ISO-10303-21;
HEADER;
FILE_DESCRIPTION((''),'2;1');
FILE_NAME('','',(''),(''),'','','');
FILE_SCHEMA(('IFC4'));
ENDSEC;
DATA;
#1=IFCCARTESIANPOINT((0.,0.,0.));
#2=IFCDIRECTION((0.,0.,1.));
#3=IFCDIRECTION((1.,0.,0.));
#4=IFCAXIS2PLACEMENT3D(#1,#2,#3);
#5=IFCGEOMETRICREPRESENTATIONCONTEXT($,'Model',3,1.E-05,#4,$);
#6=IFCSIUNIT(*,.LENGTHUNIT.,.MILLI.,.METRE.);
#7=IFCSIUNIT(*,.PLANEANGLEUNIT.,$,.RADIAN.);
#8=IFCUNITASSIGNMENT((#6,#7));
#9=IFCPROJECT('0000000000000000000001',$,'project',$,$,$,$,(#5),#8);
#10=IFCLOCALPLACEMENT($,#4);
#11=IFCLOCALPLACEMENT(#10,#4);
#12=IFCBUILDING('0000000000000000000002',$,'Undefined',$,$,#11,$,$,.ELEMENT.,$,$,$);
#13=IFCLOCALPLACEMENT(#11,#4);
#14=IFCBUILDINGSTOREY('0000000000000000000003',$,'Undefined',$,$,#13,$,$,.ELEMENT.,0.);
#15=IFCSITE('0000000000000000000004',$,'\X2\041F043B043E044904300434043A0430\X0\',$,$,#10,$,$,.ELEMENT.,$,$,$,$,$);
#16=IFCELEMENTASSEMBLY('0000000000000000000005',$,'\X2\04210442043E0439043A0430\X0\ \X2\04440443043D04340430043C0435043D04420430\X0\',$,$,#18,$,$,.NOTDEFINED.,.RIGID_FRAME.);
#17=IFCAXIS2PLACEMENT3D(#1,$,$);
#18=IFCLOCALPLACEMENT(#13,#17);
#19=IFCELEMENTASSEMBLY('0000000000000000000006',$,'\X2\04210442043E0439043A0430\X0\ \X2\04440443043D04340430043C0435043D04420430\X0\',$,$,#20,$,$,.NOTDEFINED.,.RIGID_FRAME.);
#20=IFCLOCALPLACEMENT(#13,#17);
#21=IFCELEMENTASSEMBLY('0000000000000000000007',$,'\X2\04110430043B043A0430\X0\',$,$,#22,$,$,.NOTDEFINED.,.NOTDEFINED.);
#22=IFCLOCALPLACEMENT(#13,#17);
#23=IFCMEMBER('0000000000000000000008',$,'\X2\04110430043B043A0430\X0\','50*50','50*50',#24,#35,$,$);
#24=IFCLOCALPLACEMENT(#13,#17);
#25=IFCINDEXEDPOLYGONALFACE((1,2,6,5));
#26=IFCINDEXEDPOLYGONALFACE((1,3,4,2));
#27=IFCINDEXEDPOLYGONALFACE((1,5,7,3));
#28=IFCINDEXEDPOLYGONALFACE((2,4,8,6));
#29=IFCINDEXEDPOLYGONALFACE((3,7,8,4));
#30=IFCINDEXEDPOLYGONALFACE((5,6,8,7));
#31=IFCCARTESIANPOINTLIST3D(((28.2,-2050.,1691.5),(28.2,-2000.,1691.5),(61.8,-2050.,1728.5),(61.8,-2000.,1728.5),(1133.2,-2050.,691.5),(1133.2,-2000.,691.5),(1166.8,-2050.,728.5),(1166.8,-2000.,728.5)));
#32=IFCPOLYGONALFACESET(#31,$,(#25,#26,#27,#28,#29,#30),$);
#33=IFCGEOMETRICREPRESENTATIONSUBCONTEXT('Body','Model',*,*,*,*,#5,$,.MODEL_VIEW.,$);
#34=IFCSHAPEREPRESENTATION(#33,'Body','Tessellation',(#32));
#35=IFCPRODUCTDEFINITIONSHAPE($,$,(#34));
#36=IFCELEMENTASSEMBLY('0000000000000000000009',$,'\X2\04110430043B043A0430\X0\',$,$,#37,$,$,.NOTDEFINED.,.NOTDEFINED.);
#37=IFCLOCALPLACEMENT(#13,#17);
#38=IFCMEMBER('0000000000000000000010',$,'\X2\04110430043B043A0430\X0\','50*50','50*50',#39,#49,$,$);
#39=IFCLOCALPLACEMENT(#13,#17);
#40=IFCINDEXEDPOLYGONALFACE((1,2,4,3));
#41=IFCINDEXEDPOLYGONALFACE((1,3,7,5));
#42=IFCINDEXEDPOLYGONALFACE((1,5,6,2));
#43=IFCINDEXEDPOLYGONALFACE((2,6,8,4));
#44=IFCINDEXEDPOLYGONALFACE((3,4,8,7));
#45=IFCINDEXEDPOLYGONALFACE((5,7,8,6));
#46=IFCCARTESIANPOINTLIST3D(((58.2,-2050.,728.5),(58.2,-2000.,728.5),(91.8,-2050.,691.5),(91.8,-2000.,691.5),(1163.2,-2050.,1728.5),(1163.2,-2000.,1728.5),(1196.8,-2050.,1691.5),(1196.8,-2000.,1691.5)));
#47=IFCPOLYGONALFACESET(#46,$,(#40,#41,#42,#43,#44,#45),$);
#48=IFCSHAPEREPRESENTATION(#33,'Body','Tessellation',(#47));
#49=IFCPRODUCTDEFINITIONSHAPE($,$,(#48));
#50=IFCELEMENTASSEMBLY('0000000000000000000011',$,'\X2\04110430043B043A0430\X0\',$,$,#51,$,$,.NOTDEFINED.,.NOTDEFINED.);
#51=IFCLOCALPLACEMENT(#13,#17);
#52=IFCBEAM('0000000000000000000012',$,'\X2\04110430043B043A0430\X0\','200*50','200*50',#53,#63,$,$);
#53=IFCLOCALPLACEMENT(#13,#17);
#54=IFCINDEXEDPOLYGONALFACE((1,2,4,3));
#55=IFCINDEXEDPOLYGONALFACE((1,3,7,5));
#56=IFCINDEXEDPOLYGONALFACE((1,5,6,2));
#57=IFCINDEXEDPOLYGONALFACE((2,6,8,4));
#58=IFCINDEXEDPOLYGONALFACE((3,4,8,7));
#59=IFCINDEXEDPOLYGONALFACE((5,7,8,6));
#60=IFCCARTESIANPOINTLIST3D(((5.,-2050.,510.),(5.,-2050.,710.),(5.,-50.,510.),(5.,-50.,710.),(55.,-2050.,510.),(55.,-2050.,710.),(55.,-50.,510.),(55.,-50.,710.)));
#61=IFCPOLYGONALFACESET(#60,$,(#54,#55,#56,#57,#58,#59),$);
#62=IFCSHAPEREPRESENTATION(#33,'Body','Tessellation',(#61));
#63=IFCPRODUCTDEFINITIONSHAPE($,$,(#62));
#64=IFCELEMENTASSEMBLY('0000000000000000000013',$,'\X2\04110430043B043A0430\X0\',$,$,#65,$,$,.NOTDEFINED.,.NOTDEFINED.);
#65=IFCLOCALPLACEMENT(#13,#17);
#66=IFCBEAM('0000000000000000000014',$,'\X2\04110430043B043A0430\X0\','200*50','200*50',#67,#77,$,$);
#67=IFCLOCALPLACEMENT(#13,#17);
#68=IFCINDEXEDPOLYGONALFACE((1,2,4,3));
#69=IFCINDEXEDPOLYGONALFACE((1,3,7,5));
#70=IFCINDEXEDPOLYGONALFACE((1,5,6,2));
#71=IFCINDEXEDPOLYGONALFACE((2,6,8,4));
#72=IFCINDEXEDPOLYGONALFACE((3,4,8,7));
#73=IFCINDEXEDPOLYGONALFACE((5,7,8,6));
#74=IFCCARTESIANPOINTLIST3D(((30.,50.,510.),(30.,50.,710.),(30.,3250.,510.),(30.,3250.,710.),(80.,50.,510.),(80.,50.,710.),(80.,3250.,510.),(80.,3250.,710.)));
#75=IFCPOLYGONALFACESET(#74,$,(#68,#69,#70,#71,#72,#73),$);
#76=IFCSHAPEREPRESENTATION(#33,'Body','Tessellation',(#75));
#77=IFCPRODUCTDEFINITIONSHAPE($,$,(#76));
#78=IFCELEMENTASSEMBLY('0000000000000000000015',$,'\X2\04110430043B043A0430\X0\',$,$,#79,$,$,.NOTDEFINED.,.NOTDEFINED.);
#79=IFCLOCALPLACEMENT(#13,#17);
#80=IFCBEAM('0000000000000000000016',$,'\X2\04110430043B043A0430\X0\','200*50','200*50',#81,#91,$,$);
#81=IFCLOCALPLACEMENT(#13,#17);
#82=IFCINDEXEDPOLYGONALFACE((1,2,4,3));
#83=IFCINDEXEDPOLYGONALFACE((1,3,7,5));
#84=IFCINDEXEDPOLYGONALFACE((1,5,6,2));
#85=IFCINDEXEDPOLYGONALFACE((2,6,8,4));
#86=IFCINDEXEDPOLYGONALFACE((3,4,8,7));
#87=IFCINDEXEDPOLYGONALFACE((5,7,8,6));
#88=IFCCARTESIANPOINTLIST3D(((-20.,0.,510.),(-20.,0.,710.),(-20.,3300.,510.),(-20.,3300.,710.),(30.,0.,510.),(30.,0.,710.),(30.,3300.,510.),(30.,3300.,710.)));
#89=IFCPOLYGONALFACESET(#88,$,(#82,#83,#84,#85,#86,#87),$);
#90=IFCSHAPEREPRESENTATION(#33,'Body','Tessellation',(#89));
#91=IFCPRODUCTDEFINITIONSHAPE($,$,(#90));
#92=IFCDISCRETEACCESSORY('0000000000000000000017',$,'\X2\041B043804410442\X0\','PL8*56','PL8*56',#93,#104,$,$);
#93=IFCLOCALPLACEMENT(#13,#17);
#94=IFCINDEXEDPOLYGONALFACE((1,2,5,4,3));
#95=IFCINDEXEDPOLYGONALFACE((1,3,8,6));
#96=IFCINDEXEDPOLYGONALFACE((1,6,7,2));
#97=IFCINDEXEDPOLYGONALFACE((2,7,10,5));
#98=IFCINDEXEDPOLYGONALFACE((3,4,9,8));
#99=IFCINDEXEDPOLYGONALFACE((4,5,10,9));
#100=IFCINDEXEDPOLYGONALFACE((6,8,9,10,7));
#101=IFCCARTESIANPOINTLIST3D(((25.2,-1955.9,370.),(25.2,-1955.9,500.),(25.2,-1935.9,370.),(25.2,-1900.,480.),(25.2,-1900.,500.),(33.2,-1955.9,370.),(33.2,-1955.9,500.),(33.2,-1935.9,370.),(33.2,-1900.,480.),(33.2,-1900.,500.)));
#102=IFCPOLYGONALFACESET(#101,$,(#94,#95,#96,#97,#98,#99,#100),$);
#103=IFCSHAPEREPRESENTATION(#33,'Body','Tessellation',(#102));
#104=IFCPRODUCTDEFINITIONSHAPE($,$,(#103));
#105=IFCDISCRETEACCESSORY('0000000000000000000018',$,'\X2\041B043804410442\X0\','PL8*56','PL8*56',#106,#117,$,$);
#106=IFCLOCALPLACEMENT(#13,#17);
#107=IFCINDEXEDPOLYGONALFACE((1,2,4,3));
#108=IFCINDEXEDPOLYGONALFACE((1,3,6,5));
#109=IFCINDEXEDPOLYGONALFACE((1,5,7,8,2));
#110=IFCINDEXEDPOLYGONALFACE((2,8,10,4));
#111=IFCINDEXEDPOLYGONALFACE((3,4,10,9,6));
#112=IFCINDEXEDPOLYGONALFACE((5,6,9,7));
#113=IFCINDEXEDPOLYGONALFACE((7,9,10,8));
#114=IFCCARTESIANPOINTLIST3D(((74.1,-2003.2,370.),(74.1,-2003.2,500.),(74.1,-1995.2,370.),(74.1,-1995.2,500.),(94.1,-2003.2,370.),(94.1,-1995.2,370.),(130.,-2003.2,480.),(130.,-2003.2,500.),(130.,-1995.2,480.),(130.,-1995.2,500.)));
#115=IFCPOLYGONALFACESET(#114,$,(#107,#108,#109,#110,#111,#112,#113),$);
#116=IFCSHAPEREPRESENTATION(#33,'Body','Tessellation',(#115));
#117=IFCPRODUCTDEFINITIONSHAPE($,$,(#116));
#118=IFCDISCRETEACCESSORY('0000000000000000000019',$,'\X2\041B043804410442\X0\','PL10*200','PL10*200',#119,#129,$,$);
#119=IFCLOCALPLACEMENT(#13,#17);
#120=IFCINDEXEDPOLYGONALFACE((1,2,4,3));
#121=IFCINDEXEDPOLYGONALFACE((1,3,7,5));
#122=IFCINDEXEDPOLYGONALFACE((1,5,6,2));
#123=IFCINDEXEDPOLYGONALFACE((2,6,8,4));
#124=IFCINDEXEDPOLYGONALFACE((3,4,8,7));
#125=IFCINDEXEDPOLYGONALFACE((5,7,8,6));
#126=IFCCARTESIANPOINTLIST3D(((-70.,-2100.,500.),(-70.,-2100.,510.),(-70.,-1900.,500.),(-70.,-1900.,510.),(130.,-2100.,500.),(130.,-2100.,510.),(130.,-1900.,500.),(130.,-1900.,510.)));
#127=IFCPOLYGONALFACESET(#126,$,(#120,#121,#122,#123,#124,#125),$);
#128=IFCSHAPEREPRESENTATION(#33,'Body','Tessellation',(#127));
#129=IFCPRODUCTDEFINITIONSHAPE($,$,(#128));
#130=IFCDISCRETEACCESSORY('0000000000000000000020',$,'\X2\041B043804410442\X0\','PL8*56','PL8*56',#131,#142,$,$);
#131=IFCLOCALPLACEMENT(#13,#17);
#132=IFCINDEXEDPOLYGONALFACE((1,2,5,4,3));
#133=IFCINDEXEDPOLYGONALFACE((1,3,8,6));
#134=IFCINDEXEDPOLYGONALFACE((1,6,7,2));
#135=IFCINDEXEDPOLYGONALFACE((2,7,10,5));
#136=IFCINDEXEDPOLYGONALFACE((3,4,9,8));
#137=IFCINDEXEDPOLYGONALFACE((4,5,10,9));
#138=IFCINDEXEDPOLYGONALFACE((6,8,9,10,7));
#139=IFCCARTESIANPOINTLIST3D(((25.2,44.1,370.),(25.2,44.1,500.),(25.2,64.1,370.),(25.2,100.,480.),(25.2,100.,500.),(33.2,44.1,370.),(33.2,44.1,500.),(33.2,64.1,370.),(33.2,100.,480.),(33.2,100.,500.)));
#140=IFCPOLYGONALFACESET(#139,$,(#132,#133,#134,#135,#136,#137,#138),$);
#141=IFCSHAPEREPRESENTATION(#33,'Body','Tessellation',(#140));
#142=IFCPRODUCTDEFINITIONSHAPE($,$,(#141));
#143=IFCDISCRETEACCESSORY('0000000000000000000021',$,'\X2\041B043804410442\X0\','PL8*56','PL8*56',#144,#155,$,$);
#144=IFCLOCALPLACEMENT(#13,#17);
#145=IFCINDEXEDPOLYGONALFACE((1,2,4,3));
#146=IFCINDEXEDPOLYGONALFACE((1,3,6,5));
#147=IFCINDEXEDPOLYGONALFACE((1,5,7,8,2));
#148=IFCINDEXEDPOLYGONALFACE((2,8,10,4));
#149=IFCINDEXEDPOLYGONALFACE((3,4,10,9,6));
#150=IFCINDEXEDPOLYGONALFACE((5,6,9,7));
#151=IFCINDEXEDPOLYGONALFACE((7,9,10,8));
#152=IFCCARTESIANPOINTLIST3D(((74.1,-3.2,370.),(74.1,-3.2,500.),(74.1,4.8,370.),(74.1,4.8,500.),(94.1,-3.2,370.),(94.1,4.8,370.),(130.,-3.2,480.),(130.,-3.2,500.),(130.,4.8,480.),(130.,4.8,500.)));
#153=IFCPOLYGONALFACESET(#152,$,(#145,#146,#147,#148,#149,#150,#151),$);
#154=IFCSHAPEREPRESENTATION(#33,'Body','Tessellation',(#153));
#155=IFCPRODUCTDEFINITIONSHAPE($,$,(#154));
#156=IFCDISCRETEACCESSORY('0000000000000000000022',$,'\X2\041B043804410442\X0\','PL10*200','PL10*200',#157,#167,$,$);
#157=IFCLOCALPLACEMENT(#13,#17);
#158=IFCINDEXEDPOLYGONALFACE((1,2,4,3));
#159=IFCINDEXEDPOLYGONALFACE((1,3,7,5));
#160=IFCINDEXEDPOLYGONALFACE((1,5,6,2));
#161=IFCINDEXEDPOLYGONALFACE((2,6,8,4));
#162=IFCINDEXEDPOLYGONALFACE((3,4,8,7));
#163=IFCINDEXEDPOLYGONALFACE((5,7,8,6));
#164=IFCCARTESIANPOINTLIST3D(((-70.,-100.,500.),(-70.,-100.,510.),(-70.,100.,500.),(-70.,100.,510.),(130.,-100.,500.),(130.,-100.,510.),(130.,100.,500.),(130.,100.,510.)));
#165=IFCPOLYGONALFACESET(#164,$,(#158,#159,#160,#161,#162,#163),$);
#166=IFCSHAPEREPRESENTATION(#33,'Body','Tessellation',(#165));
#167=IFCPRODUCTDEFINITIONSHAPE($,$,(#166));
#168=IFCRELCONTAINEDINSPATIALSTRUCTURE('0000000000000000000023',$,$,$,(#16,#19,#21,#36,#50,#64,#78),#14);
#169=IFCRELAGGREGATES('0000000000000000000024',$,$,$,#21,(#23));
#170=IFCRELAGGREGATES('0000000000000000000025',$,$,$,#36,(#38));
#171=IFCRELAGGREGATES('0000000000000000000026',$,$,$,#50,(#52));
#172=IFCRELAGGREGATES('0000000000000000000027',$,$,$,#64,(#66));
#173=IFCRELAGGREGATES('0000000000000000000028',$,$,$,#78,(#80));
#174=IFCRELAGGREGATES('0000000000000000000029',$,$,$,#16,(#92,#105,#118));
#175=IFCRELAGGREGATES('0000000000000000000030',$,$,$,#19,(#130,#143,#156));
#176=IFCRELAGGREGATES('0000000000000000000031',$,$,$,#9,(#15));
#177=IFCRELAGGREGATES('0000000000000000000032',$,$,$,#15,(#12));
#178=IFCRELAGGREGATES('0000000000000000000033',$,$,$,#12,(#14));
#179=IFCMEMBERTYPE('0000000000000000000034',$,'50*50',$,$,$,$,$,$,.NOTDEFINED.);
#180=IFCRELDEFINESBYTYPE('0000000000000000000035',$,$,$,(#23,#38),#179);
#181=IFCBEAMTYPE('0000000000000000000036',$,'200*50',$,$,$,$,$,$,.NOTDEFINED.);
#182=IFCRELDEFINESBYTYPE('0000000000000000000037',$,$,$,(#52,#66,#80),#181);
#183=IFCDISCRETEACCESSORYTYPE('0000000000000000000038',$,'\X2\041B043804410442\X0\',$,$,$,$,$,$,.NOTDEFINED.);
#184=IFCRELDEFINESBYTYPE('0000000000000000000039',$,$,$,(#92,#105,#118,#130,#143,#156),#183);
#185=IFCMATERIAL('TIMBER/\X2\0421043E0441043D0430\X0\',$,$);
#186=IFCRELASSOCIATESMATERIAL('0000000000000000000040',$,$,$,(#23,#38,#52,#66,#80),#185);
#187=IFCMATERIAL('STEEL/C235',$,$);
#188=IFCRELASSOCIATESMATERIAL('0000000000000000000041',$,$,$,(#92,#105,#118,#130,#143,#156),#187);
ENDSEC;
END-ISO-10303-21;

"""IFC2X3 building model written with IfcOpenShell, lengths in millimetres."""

from ifc_helpers import new_model, si_unit, frame, origin_with_axes, origin_2d_with_axis, place, context, subcontext, project, spatial, polyline, rectangle, outline, extrude, material, type_object, element, aggregate, save


model = new_model("IFC2X3")

# Units and contexts
model_context = context("Model", 3, precision=1e-05, world=origin_with_axes())
body_context = subcontext(model_context, "Body", "Model", "MODEL_VIEW")
ifc_project = project(units=[si_unit("LENGTHUNIT", "METRE", prefix="MILLI"), si_unit("PLANEANGLEUNIT", "RADIAN")], contexts=[model_context])

# Site, building, storey
site_placement = place(None, origin_with_axes())
site = spatial("IfcSite", under=ifc_project, at=site_placement, Name="Площадка", CompositionType="ELEMENT")
building_placement = place(site_placement, origin_with_axes())
building = spatial("IfcBuilding", under=site, at=building_placement, Name="Undefined", CompositionType="ELEMENT")
storey_placement = place(building_placement, origin_with_axes())
storey = spatial("IfcBuildingStorey", under=building, at=storey_placement, Name="Undefined", CompositionType="ELEMENT", Elevation=0.0)

# Element assemblies
ifc_material_1 = material(Name="TIMBER/Сосна")
assembly_1_placement = place(storey_placement, origin_with_axes())
assembly_1 = element("IfcElementAssembly", 1, at=assembly_1_placement, inside=storey, Name="Стойка фундамента", AssemblyPlace="NOTDEFINED", PredefinedType="RIGID_FRAME")
ifc_material_2 = material(Name="STEEL/C235")
assembly_2_placement = place(storey_placement, origin_with_axes())
assembly_2 = element("IfcElementAssembly", 2, at=assembly_2_placement, inside=storey, Name="Стойка фундамента", AssemblyPlace="NOTDEFINED", PredefinedType="RIGID_FRAME")

# Element assemblies, members
assembly_3_placement = place(storey_placement, origin_with_axes())
assembly_3 = element("IfcElementAssembly", 3, at=assembly_3_placement, inside=storey, Name="Балка", AssemblyPlace="NOTDEFINED", PredefinedType="NOTDEFINED")
member_type = type_object("IfcMemberType", Name="50*50", PredefinedType="NOTDEFINED")
member_1_placement = place(assembly_3_placement, frame((1150.0, -2025.0, 710.0), z_axis=(0.0, 1.0, 0.0), x_axis=(-0.741456, 0.0, 0.671001)))
member_1 = element("IfcMember", 4, at=member_1_placement, type_object=member_type, material=ifc_material_1, Name="Балка", Description="50*50", ObjectType="50*50", context=body_context, shape_type="SweptSolid", body=[
    extrude(rectangle(XDim=50.0, YDim=50.0, at=origin_2d_with_axis()), frame((1490.3, 0.0, 0.0), z_axis=(-1.0, 0.0, 0.0), x_axis=(0.0, -1.0, 0.0)), (0.0, 0.0, 1.0), 1490.3),
])
aggregate(assembly_3, [member_1])
assembly_4_placement = place(storey_placement, origin_with_axes())
assembly_4 = element("IfcElementAssembly", 5, at=assembly_4_placement, inside=storey, Name="Балка", AssemblyPlace="NOTDEFINED", PredefinedType="NOTDEFINED")
member_2_placement = place(assembly_4_placement, frame((75.0, -2025.0, 710.0), z_axis=(0.0, 1.0, 0.0), x_axis=(0.741456, 0.0, 0.671001)))
member_2 = element("IfcMember", 6, at=member_2_placement, type_object=member_type, material=ifc_material_1, Name="Балка", Description="50*50", ObjectType="50*50", context=body_context, shape_type="SweptSolid", body=[
    extrude(rectangle(XDim=50.0, YDim=50.0, at=origin_2d_with_axis()), frame((1490.3, 0.0, 0.0), z_axis=(-1.0, 0.0, 0.0), x_axis=(0.0, -1.0, 0.0)), (0.0, 0.0, 1.0), 1490.3),
])
aggregate(assembly_4, [member_2])

# Element assemblies, beams
assembly_5_placement = place(storey_placement, origin_with_axes())
assembly_5 = element("IfcElementAssembly", 7, at=assembly_5_placement, inside=storey, Name="Балка", AssemblyPlace="NOTDEFINED", PredefinedType="NOTDEFINED")
beam_type = type_object("IfcBeamType", Name="200*50", PredefinedType="NOTDEFINED")
beam_1_placement = place(assembly_5_placement, frame((30.0, -2050.0, 610.0), z_axis=(0.0, 0.0, -1.0), x_axis=(0.0, 1.0, 0.0)))
beam_1 = element("IfcBeam", 8, at=beam_1_placement, type_object=beam_type, material=ifc_material_1, Name="Балка", Description="200*50", ObjectType="200*50", context=body_context, shape_type="SweptSolid", body=[
    extrude(rectangle(XDim=50.0, YDim=200.0, at=origin_2d_with_axis()), frame((2000.0, 0.0, 0.0), z_axis=(-1.0, 0.0, 0.0), x_axis=(0.0, -1.0, 0.0)), (0.0, 0.0, 1.0), 2000.0),
])
aggregate(assembly_5, [beam_1])
assembly_6_placement = place(storey_placement, origin_with_axes())
assembly_6 = element("IfcElementAssembly", 9, at=assembly_6_placement, inside=storey, Name="Балка", AssemblyPlace="NOTDEFINED", PredefinedType="NOTDEFINED")
beam_2_placement = place(assembly_6_placement, frame((55.0, 50.0, 610.0), z_axis=(0.0, 0.0, -1.0), x_axis=(0.0, 1.0, 0.0)))
beam_2 = element("IfcBeam", 10, at=beam_2_placement, type_object=beam_type, material=ifc_material_1, Name="Балка", Description="200*50", ObjectType="200*50", context=body_context, shape_type="SweptSolid", body=[
    extrude(rectangle(XDim=50.0, YDim=200.0, at=origin_2d_with_axis()), frame((3200.0, 0.0, 0.0), z_axis=(-1.0, 0.0, 0.0), x_axis=(0.0, -1.0, 0.0)), (0.0, 0.0, 1.0), 3200.0),
])
aggregate(assembly_6, [beam_2])
assembly_7_placement = place(storey_placement, origin_with_axes())
assembly_7 = element("IfcElementAssembly", 11, at=assembly_7_placement, inside=storey, Name="Балка", AssemblyPlace="NOTDEFINED", PredefinedType="NOTDEFINED")
beam_3_placement = place(assembly_7_placement, frame((5.0, 0.0, 610.0), z_axis=(0.0, 0.0, -1.0), x_axis=(0.0, 1.0, 0.0)))
beam_3 = element("IfcBeam", 12, at=beam_3_placement, type_object=beam_type, material=ifc_material_1, Name="Балка", Description="200*50", ObjectType="200*50", context=body_context, shape_type="SweptSolid", body=[
    extrude(rectangle(XDim=50.0, YDim=200.0, at=origin_2d_with_axis()), frame((3300.0, 0.0, 0.0), z_axis=(-1.0, 0.0, 0.0), x_axis=(0.0, -1.0, 0.0)), (0.0, 0.0, 1.0), 3300.0),
])
aggregate(assembly_7, [beam_3])

# Discrete accessories
discrete_accessory_type = type_object("IfcDiscreteAccessoryType", Name="Лист")
discrete_accessory_1_placement = place(assembly_1_placement, frame((29.2, -1955.9, 500.0), z_axis=(-1.0, 0.0, 0.0), x_axis=(0.0, 1.0, 0.0)))
discrete_accessory_1 = element("IfcDiscreteAccessory", 13, at=discrete_accessory_1_placement, type_object=discrete_accessory_type, material=ifc_material_2, Name="Лист", Description="PL8*56", ObjectType="PL8*56", context=body_context, shape_type="SweptSolid", body=[
    extrude(outline(polyline([(0.0, 0.0), (55.9, 0.0), (55.9, 20.0), (20.0, 130.0), (0.0, 130.0), (0.0, 0.0)])), frame((0.0, 0.0, -4.0), z_axis=(0.0, 0.0, 1.0), x_axis=(1.0, 0.0, 0.0)), (0.0, 0.0, 1.0), 8.0),
])
discrete_accessory_2_placement = place(assembly_1_placement, frame((74.1, -1999.2, 500.0), z_axis=(0.0, 1.0, 0.0), x_axis=(1.0, 0.0, 0.0)))
discrete_accessory_2 = element("IfcDiscreteAccessory", 14, at=discrete_accessory_2_placement, type_object=discrete_accessory_type, material=ifc_material_2, Name="Лист", Description="PL8*56", ObjectType="PL8*56", context=body_context, shape_type="SweptSolid", body=[
    extrude(outline(polyline([(0.0, 0.0), (55.9, 0.0), (55.9, 20.0), (20.0, 130.0), (0.0, 130.0), (0.0, 0.0)])), frame((0.0, 0.0, -4.0), z_axis=(0.0, 0.0, 1.0), x_axis=(1.0, 0.0, 0.0)), (0.0, 0.0, 1.0), 8.0),
])
discrete_accessory_3_placement = place(assembly_1_placement, frame((-70.0, -1900.0, 505.0), z_axis=(0.0, 0.0, 1.0), x_axis=(0.0, -1.0, 0.0)))
discrete_accessory_3 = element("IfcDiscreteAccessory", 15, at=discrete_accessory_3_placement, type_object=discrete_accessory_type, material=ifc_material_2, Name="Лист", Description="PL10*200", ObjectType="PL10*200", context=body_context, shape_type="SweptSolid", body=[
    extrude(outline(polyline([(0.0, 0.0), (200.0, 0.0), (200.0, 200.0), (0.0, 200.0), (0.0, 0.0)])), frame((0.0, 0.0, -5.0), z_axis=(0.0, 0.0, 1.0), x_axis=(1.0, 0.0, 0.0)), (0.0, 0.0, 1.0), 10.0),
])
aggregate(assembly_1, [discrete_accessory_1, discrete_accessory_2, discrete_accessory_3])
discrete_accessory_4_placement = place(assembly_2_placement, frame((29.2, 44.1, 500.0), z_axis=(-1.0, 0.0, 0.0), x_axis=(0.0, 1.0, 0.0)))
discrete_accessory_4 = element("IfcDiscreteAccessory", 16, at=discrete_accessory_4_placement, type_object=discrete_accessory_type, material=ifc_material_2, Name="Лист", Description="PL8*56", ObjectType="PL8*56", context=body_context, shape_type="SweptSolid", body=[
    extrude(outline(polyline([(0.0, 0.0), (55.9, 0.0), (55.9, 20.0), (20.0, 130.0), (0.0, 130.0), (0.0, 0.0)])), frame((0.0, 0.0, -4.0), z_axis=(0.0, 0.0, 1.0), x_axis=(1.0, 0.0, 0.0)), (0.0, 0.0, 1.0), 8.0),
])
discrete_accessory_5_placement = place(assembly_2_placement, frame((74.1, 0.8, 500.0), z_axis=(0.0, 1.0, 0.0), x_axis=(1.0, 0.0, 0.0)))
discrete_accessory_5 = element("IfcDiscreteAccessory", 17, at=discrete_accessory_5_placement, type_object=discrete_accessory_type, material=ifc_material_2, Name="Лист", Description="PL8*56", ObjectType="PL8*56", context=body_context, shape_type="SweptSolid", body=[
    extrude(outline(polyline([(0.0, 0.0), (55.9, 0.0), (55.9, 20.0), (20.0, 130.0), (0.0, 130.0), (0.0, 0.0)])), frame((0.0, 0.0, -4.0), z_axis=(0.0, 0.0, 1.0), x_axis=(1.0, 0.0, 0.0)), (0.0, 0.0, 1.0), 8.0),
])
discrete_accessory_6_placement = place(assembly_2_placement, frame((-70.0, 100.0, 505.0), z_axis=(0.0, 0.0, 1.0), x_axis=(0.0, -1.0, 0.0)))
discrete_accessory_6 = element("IfcDiscreteAccessory", 18, at=discrete_accessory_6_placement, type_object=discrete_accessory_type, material=ifc_material_2, Name="Лист", Description="PL10*200", ObjectType="PL10*200", context=body_context, shape_type="SweptSolid", body=[
    extrude(outline(polyline([(0.0, 0.0), (200.0, 0.0), (200.0, 200.0), (0.0, 200.0), (0.0, 0.0)])), frame((0.0, 0.0, -5.0), z_axis=(0.0, 0.0, 1.0), x_axis=(1.0, 0.0, 0.0)), (0.0, 0.0, 1.0), 10.0),
])
aggregate(assembly_2, [discrete_accessory_4, discrete_accessory_5, discrete_accessory_6])

save(model, "model.ifc")
